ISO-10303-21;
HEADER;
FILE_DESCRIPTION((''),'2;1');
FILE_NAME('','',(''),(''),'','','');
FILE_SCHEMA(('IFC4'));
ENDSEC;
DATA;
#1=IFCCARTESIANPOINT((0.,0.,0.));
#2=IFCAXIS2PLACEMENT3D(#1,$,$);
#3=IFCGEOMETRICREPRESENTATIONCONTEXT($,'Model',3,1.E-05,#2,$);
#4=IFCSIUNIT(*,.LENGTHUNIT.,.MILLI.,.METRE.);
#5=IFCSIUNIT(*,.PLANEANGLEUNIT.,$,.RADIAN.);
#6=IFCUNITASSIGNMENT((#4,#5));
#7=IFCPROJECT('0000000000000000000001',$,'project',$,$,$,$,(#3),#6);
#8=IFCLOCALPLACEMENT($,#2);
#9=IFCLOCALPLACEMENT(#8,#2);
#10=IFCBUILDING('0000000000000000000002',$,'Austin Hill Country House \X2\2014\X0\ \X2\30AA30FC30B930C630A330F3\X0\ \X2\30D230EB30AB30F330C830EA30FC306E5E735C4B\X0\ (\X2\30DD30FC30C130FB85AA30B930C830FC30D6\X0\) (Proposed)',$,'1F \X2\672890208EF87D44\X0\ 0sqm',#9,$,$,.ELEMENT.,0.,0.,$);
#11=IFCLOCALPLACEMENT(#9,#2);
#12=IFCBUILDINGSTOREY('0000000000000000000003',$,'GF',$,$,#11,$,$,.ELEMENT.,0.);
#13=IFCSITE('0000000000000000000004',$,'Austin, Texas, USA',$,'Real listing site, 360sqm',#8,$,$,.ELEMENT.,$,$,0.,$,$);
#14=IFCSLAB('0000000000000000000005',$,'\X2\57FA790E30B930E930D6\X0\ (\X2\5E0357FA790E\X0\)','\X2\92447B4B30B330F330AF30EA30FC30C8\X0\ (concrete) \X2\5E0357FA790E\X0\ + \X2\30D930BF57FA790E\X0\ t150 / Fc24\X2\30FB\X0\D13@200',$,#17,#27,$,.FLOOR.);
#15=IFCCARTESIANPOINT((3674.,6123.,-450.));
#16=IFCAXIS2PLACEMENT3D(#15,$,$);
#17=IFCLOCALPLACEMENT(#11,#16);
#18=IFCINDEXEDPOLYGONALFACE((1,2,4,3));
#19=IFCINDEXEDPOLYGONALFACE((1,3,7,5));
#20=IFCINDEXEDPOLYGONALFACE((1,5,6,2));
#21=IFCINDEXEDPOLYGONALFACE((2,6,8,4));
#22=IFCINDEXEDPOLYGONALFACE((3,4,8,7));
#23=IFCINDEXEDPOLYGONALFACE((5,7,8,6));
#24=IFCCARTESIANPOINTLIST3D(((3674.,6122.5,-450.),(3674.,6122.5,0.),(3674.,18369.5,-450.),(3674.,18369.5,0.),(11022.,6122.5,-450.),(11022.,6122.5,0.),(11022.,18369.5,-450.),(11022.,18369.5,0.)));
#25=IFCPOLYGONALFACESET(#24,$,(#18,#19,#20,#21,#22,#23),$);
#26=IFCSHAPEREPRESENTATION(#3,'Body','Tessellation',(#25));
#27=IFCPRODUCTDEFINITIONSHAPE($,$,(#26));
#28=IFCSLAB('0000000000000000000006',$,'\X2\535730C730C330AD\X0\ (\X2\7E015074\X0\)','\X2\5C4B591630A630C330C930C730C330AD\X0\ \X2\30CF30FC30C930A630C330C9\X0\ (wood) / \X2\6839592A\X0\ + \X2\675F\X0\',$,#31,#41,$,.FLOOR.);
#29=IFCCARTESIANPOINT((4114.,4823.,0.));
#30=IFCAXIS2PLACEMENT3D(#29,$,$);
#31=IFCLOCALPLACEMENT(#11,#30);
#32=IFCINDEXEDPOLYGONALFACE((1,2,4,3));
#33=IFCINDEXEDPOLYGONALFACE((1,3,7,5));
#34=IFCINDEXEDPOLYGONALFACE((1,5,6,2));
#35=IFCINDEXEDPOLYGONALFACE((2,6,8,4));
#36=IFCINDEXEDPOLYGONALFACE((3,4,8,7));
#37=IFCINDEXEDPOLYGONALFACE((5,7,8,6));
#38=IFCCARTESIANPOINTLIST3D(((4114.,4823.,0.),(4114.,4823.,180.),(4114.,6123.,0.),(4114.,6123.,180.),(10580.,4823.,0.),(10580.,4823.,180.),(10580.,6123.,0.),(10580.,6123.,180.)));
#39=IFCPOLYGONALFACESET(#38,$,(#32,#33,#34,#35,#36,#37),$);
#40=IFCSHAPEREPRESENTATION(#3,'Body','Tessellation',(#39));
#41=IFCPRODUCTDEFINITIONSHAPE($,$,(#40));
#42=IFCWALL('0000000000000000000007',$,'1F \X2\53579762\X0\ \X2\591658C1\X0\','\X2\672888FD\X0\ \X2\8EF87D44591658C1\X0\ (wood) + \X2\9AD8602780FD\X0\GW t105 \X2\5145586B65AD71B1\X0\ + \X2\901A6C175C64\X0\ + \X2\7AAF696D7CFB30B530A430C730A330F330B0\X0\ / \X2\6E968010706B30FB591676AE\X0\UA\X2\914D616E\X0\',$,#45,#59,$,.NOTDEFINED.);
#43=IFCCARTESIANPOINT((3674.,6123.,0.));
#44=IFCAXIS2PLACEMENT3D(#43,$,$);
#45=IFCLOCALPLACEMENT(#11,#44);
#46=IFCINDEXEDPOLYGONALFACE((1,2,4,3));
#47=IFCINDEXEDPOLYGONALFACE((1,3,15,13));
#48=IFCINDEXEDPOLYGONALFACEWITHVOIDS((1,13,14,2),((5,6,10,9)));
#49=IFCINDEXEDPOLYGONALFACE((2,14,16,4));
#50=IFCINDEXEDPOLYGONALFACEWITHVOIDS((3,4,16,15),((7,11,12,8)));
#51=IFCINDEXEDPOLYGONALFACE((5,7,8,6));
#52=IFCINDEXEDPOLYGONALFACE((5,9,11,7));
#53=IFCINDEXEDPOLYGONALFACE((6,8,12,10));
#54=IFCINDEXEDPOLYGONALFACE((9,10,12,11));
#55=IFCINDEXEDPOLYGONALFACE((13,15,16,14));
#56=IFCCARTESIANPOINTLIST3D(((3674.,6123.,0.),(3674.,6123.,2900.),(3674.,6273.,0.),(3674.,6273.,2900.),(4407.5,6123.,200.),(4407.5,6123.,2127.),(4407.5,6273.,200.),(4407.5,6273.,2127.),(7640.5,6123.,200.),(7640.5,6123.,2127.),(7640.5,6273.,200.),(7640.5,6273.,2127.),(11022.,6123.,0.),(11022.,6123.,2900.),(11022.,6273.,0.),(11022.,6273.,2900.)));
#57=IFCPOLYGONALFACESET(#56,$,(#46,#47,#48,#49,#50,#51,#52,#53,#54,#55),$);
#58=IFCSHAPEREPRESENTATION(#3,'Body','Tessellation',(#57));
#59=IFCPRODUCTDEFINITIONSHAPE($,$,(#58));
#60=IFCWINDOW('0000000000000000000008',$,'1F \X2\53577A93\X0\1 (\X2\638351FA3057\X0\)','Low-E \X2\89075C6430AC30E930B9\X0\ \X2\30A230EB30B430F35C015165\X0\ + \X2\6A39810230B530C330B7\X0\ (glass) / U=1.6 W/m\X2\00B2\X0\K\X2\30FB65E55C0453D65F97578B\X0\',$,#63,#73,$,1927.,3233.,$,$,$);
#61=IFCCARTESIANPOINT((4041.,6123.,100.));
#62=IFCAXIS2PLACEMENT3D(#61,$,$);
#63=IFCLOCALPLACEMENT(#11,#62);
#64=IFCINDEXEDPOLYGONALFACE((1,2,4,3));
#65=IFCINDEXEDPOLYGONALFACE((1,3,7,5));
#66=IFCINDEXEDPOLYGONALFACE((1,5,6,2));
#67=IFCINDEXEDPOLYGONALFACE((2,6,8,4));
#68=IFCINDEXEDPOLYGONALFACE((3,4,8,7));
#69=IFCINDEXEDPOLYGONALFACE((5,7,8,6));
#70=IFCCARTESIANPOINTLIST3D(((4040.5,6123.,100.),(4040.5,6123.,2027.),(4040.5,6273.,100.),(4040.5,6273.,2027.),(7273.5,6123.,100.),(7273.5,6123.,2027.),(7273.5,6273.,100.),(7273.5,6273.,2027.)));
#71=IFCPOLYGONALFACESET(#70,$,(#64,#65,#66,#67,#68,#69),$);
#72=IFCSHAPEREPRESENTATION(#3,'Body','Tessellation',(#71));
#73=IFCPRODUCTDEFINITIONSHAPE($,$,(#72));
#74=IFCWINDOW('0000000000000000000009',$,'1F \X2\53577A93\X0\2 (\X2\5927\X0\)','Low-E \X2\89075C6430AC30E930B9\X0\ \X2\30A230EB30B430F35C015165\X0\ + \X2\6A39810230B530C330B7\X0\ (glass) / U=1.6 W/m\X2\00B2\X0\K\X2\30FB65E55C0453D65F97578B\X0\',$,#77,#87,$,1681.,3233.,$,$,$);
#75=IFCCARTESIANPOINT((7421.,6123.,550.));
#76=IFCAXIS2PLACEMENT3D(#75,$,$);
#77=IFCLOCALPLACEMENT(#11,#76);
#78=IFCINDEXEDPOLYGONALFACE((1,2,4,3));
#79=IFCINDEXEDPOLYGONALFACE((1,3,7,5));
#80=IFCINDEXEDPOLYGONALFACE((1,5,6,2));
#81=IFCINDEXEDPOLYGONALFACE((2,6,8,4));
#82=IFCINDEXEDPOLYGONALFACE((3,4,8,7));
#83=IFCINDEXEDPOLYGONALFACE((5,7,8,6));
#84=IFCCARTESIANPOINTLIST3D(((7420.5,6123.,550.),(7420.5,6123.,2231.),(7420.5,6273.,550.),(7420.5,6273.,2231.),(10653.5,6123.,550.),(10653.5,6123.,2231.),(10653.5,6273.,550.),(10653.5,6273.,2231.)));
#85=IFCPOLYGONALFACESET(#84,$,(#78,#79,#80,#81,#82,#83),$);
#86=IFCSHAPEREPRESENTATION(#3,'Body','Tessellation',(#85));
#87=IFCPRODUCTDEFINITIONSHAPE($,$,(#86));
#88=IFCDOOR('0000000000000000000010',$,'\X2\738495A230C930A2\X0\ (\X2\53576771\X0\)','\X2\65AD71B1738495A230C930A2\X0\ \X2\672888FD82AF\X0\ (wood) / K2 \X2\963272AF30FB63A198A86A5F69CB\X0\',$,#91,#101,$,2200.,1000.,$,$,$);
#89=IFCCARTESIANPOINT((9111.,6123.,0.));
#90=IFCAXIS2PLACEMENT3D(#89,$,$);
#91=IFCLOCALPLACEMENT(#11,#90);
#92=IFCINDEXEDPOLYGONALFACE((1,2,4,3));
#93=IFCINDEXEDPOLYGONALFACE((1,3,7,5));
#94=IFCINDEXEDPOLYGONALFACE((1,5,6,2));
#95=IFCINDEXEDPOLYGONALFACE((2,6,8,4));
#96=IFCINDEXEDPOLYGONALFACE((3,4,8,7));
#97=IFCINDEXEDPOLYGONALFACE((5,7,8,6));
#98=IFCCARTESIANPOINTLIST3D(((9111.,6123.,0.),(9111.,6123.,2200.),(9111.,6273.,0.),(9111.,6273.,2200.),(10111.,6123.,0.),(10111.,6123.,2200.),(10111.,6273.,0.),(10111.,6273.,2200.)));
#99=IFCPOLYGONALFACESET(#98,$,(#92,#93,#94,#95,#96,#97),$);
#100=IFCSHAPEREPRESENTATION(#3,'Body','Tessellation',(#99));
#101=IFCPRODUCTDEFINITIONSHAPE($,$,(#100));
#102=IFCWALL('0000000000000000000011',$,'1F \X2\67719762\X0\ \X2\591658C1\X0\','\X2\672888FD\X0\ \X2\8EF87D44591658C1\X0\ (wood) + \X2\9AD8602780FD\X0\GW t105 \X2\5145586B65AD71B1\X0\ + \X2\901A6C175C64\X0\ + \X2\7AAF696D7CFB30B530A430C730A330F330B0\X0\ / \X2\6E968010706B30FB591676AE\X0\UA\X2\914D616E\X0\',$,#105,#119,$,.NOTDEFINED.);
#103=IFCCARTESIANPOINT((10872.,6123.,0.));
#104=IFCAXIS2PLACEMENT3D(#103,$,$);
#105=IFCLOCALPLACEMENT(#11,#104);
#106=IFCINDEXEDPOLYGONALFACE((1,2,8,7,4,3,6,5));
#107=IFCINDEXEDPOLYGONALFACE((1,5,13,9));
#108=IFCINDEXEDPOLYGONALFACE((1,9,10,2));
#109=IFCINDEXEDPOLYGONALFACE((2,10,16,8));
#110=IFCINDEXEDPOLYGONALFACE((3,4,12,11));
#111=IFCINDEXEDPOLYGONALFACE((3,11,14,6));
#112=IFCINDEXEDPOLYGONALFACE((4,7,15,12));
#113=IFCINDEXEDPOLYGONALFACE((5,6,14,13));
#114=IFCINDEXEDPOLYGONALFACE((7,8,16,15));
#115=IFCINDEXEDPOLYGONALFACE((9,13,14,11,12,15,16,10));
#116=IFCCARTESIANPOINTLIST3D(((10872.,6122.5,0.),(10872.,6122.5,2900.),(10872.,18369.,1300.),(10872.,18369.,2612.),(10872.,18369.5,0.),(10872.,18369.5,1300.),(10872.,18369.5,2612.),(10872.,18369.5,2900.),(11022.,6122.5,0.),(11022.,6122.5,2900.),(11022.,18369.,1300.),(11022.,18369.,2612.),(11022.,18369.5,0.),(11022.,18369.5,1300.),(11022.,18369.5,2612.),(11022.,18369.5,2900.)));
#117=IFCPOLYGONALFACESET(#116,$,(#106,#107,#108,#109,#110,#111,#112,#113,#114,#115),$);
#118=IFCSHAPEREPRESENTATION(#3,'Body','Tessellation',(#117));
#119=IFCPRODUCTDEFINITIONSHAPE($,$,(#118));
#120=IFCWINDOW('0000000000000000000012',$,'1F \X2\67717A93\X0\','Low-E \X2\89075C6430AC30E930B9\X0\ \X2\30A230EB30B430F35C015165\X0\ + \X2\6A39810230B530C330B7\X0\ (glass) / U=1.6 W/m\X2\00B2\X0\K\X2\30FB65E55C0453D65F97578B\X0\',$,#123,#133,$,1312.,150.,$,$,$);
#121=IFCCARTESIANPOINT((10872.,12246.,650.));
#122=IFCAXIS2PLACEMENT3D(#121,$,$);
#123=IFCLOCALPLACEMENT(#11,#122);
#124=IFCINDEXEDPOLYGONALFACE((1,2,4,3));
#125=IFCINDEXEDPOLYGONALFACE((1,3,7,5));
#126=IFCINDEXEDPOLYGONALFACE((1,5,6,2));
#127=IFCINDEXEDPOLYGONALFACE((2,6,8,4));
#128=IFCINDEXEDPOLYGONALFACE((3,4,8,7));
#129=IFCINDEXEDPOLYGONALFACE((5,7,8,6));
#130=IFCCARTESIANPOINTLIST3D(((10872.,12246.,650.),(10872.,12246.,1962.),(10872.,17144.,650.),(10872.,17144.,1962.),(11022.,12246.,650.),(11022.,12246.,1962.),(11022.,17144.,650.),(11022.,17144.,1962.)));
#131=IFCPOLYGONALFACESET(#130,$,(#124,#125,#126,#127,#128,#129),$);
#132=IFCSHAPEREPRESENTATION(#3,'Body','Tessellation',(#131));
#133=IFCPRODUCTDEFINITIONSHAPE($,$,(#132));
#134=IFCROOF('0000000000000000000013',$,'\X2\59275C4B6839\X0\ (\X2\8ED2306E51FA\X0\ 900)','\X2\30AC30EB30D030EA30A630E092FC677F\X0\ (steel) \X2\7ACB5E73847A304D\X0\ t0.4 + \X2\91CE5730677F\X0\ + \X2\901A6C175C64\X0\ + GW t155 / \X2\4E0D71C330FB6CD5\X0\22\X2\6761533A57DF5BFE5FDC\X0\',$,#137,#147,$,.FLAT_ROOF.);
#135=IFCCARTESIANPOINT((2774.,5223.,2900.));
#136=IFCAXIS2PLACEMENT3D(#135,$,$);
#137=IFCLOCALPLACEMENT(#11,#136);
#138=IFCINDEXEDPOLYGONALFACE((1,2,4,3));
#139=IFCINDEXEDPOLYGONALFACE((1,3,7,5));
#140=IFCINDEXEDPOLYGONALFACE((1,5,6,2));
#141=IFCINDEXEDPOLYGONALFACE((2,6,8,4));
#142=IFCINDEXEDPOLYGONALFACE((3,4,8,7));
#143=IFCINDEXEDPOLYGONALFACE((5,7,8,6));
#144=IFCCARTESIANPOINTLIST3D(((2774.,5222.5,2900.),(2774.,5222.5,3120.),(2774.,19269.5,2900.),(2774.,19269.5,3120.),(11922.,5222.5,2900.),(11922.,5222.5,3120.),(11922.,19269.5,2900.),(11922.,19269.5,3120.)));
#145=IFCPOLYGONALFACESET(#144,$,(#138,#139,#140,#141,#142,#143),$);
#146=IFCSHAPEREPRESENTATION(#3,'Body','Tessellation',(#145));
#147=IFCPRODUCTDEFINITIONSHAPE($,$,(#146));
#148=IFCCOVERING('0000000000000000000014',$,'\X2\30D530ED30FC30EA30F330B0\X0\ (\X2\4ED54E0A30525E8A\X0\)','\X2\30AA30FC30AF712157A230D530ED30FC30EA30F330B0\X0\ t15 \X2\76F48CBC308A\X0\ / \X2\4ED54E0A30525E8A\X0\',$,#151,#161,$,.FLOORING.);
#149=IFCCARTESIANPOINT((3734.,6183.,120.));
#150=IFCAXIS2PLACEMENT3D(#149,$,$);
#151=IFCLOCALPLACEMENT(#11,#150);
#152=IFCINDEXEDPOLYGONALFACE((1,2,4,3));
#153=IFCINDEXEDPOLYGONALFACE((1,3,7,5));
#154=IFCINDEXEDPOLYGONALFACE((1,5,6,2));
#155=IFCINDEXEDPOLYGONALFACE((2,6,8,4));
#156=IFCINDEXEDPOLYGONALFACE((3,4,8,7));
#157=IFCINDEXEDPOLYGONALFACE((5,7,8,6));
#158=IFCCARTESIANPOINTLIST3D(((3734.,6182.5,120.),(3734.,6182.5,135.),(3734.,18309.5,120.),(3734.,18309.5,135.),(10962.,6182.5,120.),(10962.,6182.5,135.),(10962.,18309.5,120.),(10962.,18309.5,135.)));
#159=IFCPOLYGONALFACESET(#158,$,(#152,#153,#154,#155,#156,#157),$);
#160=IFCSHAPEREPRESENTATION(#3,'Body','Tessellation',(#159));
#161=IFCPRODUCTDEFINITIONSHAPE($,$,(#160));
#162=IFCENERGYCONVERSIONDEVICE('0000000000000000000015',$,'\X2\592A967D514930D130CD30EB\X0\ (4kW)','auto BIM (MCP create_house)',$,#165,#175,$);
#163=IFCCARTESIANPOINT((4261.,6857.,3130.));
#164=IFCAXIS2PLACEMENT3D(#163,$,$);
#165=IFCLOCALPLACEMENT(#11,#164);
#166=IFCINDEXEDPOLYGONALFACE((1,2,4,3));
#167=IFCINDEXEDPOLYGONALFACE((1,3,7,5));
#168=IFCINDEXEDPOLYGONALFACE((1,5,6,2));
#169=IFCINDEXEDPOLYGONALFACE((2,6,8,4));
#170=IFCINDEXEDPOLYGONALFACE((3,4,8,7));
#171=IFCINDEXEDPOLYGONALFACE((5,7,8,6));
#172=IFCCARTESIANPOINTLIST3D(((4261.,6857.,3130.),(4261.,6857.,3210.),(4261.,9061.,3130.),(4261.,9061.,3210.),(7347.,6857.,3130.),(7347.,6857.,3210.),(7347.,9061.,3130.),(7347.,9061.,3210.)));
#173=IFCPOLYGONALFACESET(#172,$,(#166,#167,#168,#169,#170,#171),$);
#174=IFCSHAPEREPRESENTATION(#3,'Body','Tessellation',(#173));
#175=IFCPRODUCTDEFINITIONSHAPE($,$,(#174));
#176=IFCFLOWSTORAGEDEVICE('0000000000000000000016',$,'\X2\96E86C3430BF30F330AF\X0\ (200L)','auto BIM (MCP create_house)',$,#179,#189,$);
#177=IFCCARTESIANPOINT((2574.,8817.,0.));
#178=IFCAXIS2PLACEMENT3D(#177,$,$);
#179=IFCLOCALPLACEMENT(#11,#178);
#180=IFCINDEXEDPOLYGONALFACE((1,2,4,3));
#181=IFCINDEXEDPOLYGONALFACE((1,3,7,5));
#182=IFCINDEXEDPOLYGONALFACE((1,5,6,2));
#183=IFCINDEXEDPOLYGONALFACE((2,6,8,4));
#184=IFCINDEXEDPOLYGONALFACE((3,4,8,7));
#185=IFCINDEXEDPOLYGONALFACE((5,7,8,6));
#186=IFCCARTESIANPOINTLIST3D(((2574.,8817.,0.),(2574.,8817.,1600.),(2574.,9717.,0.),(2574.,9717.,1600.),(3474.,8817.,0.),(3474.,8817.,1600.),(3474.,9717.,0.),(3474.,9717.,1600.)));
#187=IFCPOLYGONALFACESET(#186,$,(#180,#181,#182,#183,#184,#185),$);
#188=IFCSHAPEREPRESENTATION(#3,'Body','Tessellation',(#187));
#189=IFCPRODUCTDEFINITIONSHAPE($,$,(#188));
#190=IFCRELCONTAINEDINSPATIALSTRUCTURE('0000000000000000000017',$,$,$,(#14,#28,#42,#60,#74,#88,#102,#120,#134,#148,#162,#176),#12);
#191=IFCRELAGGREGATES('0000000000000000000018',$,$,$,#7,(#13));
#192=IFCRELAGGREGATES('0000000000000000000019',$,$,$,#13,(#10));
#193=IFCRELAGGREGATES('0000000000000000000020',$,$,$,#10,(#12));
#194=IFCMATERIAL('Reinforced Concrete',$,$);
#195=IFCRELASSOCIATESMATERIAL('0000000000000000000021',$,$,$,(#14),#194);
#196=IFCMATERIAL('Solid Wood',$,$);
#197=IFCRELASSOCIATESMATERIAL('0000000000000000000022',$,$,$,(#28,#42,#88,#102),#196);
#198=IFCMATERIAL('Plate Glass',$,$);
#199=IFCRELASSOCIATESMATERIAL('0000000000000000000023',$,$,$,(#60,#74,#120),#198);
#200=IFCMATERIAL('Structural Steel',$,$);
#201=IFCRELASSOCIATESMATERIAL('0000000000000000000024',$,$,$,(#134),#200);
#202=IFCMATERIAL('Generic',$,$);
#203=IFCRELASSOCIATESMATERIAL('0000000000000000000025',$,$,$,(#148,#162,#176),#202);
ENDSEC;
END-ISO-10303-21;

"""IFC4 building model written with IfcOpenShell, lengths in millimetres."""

from ifc_helpers import new_model, si_unit, frame, frame_2d, origin, place, context, project, spatial, rectangle, extrude, material, element, fill, save


model = new_model("IFC4")

# Units and contexts
model_context = context("Model", 3, precision=1e-05, world=origin())
ifc_project = project(units=[si_unit("LENGTHUNIT", "METRE", prefix="MILLI"), si_unit("PLANEANGLEUNIT", "RADIAN")], contexts=[model_context])

# Site, building, storey
site_placement = place(None, origin())
site = spatial("IfcSite", under=ifc_project, at=site_placement, Name="Austin, Texas, USA", ObjectType="Real listing site, 360sqm", CompositionType="ELEMENT", RefElevation=0.0)
building_placement = place(site_placement, origin())
building = spatial("IfcBuilding", under=site, at=building_placement, Name="Austin Hill Country House — オースティン ヒルカントリーの平屋 (ポーチ・薪ストーブ) (Proposed)", ObjectType="1F 木造軸組 0sqm", CompositionType="ELEMENT", ElevationOfRefHeight=0.0, ElevationOfTerrain=0.0)
storey_placement = place(building_placement, origin())
storey = spatial("IfcBuildingStorey", under=building, at=storey_placement, Name="GF", CompositionType="ELEMENT", Elevation=0.0)

# Slabs
ifc_material_1 = material(Name="Reinforced Concrete")
slab_1_placement = place(storey_placement, frame((3674.0, 6123.0, -450.0)))
element("IfcSlab", 1, at=slab_1_placement, inside=storey, material=ifc_material_1, Name="基礎スラブ (布基礎)", Description="鉄筋コンクリート (concrete) 布基礎 + ベタ基礎 t150 / Fc24・D13@200", PredefinedType="FLOOR", context=model_context, shape_type="SweptSolid", body=[
    extrude(rectangle(XDim=7348.0, YDim=12247.0, at=frame_2d((3674.0, 6123.0))), frame((3674.0, 6123.0, -450.0)), (0.0, 0.0, 1.0), 450.0),
])
ifc_material_2 = material(Name="Solid Wood")
slab_2_placement = place(storey_placement, frame((4114.0, 4823.0, 0.0)))
element("IfcSlab", 2, at=slab_2_placement, inside=storey, material=ifc_material_2, Name="南デッキ (縁側)", Description="屋外ウッドデッキ ハードウッド (wood) / 根太 + 束", PredefinedType="FLOOR", context=model_context, shape_type="SweptSolid", body=[
    extrude(rectangle(XDim=6466.0, YDim=1300.0, at=frame_2d((3233.0, 650.0))), frame((4114.0, 4823.0, 0.0)), (0.0, 0.0, 1.0), 180.0),
])

# Wall, openings, windows, door
wall_1_placement = place(storey_placement, frame((3674.0, 6123.0, 0.0)))
wall_1 = element("IfcWall", 3, at=wall_1_placement, inside=storey, material=ifc_material_2, Name="1F 南面 外壁", Description="木製 軸組外壁 (wood) + 高性能GW t105 充填断熱 + 通気層 + 窯業系サイディング / 準耐火・外皮UA配慮", PredefinedType="NOTDEFINED", context=model_context, shape_type="SweptSolid", body=[
    extrude(rectangle(XDim=7348.0, YDim=150.0, at=frame_2d((3674.0, 75.0))), frame((3674.0, 6123.0, 0.0)), (0.0, 0.0, 1.0), 2900.0),
])
opening_1_placement = place(storey_placement, frame((4041.0, 6123.0, 100.0)))
opening_1 = element("IfcOpeningElement", 4, at=opening_1_placement, cuts=wall_1, PredefinedType="NOTDEFINED", context=model_context, shape_type="SweptSolid", body=[
    extrude(rectangle(XDim=3233.0, YDim=150.0, at=frame_2d((1616.0, 75.0))), frame((4041.0, 6123.0, 100.0)), (0.0, 0.0, 1.0), 1927.0),
])
opening_2_placement = place(storey_placement, frame((7421.0, 6123.0, 550.0)))
opening_2 = element("IfcOpeningElement", 5, at=opening_2_placement, cuts=wall_1, PredefinedType="NOTDEFINED", context=model_context, shape_type="SweptSolid", body=[
    extrude(rectangle(XDim=3233.0, YDim=150.0, at=frame_2d((1616.0, 75.0))), frame((7421.0, 6123.0, 550.0)), (0.0, 0.0, 1.0), 1681.0),
])
opening_3_placement = place(storey_placement, frame((9111.0, 6123.0, 0.0)))
opening_3 = element("IfcOpeningElement", 6, at=opening_3_placement, cuts=wall_1, PredefinedType="NOTDEFINED", context=model_context, shape_type="SweptSolid", body=[
    extrude(rectangle(XDim=1000.0, YDim=150.0, at=frame_2d((500.0, 75.0))), frame((9111.0, 6123.0, 0.0)), (0.0, 0.0, 1.0), 2200.0),
])
ifc_material_3 = material(Name="Plate Glass")
window_1_placement = place(storey_placement, frame((4041.0, 6123.0, 100.0)))
window_1 = element("IfcWindow", 7, at=window_1_placement, inside=storey, material=ifc_material_3, Name="1F 南窓1 (掃出し)", Description="Low-E 複層ガラス アルゴン封入 + 樹脂サッシ (glass) / U=1.6 W/m²K・日射取得型", OverallHeight=1927.0, OverallWidth=3233.0, context=model_context, shape_type="SweptSolid", body=[
    extrude(rectangle(XDim=3233.0, YDim=150.0, at=frame_2d((1616.0, 75.0))), frame((4041.0, 6123.0, 100.0)), (0.0, 0.0, 1.0), 1927.0),
])
fill(opening_1, window_1)
window_2_placement = place(storey_placement, frame((7421.0, 6123.0, 550.0)))
window_2 = element("IfcWindow", 8, at=window_2_placement, inside=storey, material=ifc_material_3, Name="1F 南窓2 (大)", Description="Low-E 複層ガラス アルゴン封入 + 樹脂サッシ (glass) / U=1.6 W/m²K・日射取得型", OverallHeight=1681.0, OverallWidth=3233.0, context=model_context, shape_type="SweptSolid", body=[
    extrude(rectangle(XDim=3233.0, YDim=150.0, at=frame_2d((1616.0, 75.0))), frame((7421.0, 6123.0, 550.0)), (0.0, 0.0, 1.0), 1681.0),
])
fill(opening_2, window_2)
door_placement = place(storey_placement, frame((9111.0, 6123.0, 0.0)))
door = element("IfcDoor", 9, at=door_placement, inside=storey, material=ifc_material_2, Name="玄関ドア (南東)", Description="断熱玄関ドア 木製芯 (wood) / K2 防犯・採風機構", OverallHeight=2200.0, OverallWidth=1000.0, context=model_context, shape_type="SweptSolid", body=[
    extrude(rectangle(XDim=1000.0, YDim=150.0, at=frame_2d((500.0, 75.0))), frame((9111.0, 6123.0, 0.0)), (0.0, 0.0, 1.0), 2200.0),
])
fill(opening_3, door)

# Wall, opening, window
wall_2_placement = place(storey_placement, frame((10872.0, 6123.0, 0.0)))
wall_2 = element("IfcWall", 10, at=wall_2_placement, inside=storey, material=ifc_material_2, Name="1F 東面 外壁", Description="木製 軸組外壁 (wood) + 高性能GW t105 充填断熱 + 通気層 + 窯業系サイディング / 準耐火・外皮UA配慮", PredefinedType="NOTDEFINED", context=model_context, shape_type="SweptSolid", body=[
    extrude(rectangle(XDim=150.0, YDim=12247.0, at=frame_2d((75.0, 6123.0))), frame((10872.0, 6123.0, 0.0)), (0.0, 0.0, 1.0), 2900.0),
])
opening_4_placement = place(storey_placement, frame((10872.0, 12246.0, 650.0)))
opening_4 = element("IfcOpeningElement", 11, at=opening_4_placement, cuts=wall_2, PredefinedType="NOTDEFINED", context=model_context, shape_type="SweptSolid", body=[
    extrude(rectangle(XDim=150.0, YDim=4898.0, at=frame_2d((75.0, 2449.0))), frame((10872.0, 12246.0, 650.0)), (0.0, 0.0, 1.0), 1312.0),
])
window_3_placement = place(storey_placement, frame((10872.0, 12246.0, 650.0)))
window_3 = element("IfcWindow", 12, at=window_3_placement, inside=storey, material=ifc_material_3, Name="1F 東窓", Description="Low-E 複層ガラス アルゴン封入 + 樹脂サッシ (glass) / U=1.6 W/m²K・日射取得型", OverallHeight=1312.0, OverallWidth=150.0, context=model_context, shape_type="SweptSolid", body=[
    extrude(rectangle(XDim=150.0, YDim=4898.0, at=frame_2d((75.0, 2449.0))), frame((10872.0, 12246.0, 650.0)), (0.0, 0.0, 1.0), 1312.0),
])
fill(opening_4, window_3)

# Roof
ifc_material_4 = material(Name="Structural Steel")
roof_placement = place(storey_placement, frame((2774.0, 5223.0, 2900.0)))
element("IfcRoof", 13, at=roof_placement, inside=storey, material=ifc_material_4, Name="大屋根 (軒の出 900)", Description="ガルバリウム鋼板 (steel) 立平葺き t0.4 + 野地板 + 通気層 + GW t155 / 不燃・法22条区域対応", PredefinedType="FLAT_ROOF", context=model_context, shape_type="SweptSolid", body=[
    extrude(rectangle(XDim=9148.0, YDim=14047.0, at=frame_2d((4574.0, 7023.0))), frame((2774.0, 5223.0, 2900.0)), (0.0, 0.0, 1.0), 220.0),
])

# Covering
ifc_material_5 = material(Name="Generic")
covering_placement = place(storey_placement, frame((3734.0, 6183.0, 120.0)))
element("IfcCovering", 14, at=covering_placement, inside=storey, material=ifc_material_5, Name="フローリング (仕上げ床)", Description="オーク無垢フローリング t15 直貼り / 仕上げ床", PredefinedType="FLOORING", context=model_context, shape_type="SweptSolid", body=[
    extrude(rectangle(XDim=7228.0, YDim=12127.0, at=frame_2d((3614.0, 6063.0))), frame((3734.0, 6183.0, 120.0)), (0.0, 0.0, 1.0), 15.0),
])

# Energy conversion device
energy_conversion_device_placement = place(storey_placement, frame((4261.0, 6857.0, 3130.0)))
element("IfcEnergyConversionDevice", 15, at=energy_conversion_device_placement, inside=storey, material=ifc_material_5, Name="太陽光パネル (4kW)", Description="auto BIM (MCP create_house)", context=model_context, shape_type="SweptSolid", body=[
    extrude(rectangle(XDim=3086.0, YDim=2204.0, at=frame_2d((1543.0, 1102.0))), frame((4261.0, 6857.0, 3130.0)), (0.0, 0.0, 1.0), 80.0),
])

# Flow storage device
flow_storage_device_placement = place(storey_placement, frame((2574.0, 8817.0, 0.0)))
element("IfcFlowStorageDevice", 16, at=flow_storage_device_placement, inside=storey, material=ifc_material_5, Name="雨水タンク (200L)", Description="auto BIM (MCP create_house)", context=model_context, shape_type="SweptSolid", body=[
    extrude(rectangle(XDim=900.0, YDim=900.0, at=frame_2d((450.0, 450.0))), frame((2574.0, 8817.0, 0.0)), (0.0, 0.0, 1.0), 1600.0),
])

save(model, "model.ifc")
